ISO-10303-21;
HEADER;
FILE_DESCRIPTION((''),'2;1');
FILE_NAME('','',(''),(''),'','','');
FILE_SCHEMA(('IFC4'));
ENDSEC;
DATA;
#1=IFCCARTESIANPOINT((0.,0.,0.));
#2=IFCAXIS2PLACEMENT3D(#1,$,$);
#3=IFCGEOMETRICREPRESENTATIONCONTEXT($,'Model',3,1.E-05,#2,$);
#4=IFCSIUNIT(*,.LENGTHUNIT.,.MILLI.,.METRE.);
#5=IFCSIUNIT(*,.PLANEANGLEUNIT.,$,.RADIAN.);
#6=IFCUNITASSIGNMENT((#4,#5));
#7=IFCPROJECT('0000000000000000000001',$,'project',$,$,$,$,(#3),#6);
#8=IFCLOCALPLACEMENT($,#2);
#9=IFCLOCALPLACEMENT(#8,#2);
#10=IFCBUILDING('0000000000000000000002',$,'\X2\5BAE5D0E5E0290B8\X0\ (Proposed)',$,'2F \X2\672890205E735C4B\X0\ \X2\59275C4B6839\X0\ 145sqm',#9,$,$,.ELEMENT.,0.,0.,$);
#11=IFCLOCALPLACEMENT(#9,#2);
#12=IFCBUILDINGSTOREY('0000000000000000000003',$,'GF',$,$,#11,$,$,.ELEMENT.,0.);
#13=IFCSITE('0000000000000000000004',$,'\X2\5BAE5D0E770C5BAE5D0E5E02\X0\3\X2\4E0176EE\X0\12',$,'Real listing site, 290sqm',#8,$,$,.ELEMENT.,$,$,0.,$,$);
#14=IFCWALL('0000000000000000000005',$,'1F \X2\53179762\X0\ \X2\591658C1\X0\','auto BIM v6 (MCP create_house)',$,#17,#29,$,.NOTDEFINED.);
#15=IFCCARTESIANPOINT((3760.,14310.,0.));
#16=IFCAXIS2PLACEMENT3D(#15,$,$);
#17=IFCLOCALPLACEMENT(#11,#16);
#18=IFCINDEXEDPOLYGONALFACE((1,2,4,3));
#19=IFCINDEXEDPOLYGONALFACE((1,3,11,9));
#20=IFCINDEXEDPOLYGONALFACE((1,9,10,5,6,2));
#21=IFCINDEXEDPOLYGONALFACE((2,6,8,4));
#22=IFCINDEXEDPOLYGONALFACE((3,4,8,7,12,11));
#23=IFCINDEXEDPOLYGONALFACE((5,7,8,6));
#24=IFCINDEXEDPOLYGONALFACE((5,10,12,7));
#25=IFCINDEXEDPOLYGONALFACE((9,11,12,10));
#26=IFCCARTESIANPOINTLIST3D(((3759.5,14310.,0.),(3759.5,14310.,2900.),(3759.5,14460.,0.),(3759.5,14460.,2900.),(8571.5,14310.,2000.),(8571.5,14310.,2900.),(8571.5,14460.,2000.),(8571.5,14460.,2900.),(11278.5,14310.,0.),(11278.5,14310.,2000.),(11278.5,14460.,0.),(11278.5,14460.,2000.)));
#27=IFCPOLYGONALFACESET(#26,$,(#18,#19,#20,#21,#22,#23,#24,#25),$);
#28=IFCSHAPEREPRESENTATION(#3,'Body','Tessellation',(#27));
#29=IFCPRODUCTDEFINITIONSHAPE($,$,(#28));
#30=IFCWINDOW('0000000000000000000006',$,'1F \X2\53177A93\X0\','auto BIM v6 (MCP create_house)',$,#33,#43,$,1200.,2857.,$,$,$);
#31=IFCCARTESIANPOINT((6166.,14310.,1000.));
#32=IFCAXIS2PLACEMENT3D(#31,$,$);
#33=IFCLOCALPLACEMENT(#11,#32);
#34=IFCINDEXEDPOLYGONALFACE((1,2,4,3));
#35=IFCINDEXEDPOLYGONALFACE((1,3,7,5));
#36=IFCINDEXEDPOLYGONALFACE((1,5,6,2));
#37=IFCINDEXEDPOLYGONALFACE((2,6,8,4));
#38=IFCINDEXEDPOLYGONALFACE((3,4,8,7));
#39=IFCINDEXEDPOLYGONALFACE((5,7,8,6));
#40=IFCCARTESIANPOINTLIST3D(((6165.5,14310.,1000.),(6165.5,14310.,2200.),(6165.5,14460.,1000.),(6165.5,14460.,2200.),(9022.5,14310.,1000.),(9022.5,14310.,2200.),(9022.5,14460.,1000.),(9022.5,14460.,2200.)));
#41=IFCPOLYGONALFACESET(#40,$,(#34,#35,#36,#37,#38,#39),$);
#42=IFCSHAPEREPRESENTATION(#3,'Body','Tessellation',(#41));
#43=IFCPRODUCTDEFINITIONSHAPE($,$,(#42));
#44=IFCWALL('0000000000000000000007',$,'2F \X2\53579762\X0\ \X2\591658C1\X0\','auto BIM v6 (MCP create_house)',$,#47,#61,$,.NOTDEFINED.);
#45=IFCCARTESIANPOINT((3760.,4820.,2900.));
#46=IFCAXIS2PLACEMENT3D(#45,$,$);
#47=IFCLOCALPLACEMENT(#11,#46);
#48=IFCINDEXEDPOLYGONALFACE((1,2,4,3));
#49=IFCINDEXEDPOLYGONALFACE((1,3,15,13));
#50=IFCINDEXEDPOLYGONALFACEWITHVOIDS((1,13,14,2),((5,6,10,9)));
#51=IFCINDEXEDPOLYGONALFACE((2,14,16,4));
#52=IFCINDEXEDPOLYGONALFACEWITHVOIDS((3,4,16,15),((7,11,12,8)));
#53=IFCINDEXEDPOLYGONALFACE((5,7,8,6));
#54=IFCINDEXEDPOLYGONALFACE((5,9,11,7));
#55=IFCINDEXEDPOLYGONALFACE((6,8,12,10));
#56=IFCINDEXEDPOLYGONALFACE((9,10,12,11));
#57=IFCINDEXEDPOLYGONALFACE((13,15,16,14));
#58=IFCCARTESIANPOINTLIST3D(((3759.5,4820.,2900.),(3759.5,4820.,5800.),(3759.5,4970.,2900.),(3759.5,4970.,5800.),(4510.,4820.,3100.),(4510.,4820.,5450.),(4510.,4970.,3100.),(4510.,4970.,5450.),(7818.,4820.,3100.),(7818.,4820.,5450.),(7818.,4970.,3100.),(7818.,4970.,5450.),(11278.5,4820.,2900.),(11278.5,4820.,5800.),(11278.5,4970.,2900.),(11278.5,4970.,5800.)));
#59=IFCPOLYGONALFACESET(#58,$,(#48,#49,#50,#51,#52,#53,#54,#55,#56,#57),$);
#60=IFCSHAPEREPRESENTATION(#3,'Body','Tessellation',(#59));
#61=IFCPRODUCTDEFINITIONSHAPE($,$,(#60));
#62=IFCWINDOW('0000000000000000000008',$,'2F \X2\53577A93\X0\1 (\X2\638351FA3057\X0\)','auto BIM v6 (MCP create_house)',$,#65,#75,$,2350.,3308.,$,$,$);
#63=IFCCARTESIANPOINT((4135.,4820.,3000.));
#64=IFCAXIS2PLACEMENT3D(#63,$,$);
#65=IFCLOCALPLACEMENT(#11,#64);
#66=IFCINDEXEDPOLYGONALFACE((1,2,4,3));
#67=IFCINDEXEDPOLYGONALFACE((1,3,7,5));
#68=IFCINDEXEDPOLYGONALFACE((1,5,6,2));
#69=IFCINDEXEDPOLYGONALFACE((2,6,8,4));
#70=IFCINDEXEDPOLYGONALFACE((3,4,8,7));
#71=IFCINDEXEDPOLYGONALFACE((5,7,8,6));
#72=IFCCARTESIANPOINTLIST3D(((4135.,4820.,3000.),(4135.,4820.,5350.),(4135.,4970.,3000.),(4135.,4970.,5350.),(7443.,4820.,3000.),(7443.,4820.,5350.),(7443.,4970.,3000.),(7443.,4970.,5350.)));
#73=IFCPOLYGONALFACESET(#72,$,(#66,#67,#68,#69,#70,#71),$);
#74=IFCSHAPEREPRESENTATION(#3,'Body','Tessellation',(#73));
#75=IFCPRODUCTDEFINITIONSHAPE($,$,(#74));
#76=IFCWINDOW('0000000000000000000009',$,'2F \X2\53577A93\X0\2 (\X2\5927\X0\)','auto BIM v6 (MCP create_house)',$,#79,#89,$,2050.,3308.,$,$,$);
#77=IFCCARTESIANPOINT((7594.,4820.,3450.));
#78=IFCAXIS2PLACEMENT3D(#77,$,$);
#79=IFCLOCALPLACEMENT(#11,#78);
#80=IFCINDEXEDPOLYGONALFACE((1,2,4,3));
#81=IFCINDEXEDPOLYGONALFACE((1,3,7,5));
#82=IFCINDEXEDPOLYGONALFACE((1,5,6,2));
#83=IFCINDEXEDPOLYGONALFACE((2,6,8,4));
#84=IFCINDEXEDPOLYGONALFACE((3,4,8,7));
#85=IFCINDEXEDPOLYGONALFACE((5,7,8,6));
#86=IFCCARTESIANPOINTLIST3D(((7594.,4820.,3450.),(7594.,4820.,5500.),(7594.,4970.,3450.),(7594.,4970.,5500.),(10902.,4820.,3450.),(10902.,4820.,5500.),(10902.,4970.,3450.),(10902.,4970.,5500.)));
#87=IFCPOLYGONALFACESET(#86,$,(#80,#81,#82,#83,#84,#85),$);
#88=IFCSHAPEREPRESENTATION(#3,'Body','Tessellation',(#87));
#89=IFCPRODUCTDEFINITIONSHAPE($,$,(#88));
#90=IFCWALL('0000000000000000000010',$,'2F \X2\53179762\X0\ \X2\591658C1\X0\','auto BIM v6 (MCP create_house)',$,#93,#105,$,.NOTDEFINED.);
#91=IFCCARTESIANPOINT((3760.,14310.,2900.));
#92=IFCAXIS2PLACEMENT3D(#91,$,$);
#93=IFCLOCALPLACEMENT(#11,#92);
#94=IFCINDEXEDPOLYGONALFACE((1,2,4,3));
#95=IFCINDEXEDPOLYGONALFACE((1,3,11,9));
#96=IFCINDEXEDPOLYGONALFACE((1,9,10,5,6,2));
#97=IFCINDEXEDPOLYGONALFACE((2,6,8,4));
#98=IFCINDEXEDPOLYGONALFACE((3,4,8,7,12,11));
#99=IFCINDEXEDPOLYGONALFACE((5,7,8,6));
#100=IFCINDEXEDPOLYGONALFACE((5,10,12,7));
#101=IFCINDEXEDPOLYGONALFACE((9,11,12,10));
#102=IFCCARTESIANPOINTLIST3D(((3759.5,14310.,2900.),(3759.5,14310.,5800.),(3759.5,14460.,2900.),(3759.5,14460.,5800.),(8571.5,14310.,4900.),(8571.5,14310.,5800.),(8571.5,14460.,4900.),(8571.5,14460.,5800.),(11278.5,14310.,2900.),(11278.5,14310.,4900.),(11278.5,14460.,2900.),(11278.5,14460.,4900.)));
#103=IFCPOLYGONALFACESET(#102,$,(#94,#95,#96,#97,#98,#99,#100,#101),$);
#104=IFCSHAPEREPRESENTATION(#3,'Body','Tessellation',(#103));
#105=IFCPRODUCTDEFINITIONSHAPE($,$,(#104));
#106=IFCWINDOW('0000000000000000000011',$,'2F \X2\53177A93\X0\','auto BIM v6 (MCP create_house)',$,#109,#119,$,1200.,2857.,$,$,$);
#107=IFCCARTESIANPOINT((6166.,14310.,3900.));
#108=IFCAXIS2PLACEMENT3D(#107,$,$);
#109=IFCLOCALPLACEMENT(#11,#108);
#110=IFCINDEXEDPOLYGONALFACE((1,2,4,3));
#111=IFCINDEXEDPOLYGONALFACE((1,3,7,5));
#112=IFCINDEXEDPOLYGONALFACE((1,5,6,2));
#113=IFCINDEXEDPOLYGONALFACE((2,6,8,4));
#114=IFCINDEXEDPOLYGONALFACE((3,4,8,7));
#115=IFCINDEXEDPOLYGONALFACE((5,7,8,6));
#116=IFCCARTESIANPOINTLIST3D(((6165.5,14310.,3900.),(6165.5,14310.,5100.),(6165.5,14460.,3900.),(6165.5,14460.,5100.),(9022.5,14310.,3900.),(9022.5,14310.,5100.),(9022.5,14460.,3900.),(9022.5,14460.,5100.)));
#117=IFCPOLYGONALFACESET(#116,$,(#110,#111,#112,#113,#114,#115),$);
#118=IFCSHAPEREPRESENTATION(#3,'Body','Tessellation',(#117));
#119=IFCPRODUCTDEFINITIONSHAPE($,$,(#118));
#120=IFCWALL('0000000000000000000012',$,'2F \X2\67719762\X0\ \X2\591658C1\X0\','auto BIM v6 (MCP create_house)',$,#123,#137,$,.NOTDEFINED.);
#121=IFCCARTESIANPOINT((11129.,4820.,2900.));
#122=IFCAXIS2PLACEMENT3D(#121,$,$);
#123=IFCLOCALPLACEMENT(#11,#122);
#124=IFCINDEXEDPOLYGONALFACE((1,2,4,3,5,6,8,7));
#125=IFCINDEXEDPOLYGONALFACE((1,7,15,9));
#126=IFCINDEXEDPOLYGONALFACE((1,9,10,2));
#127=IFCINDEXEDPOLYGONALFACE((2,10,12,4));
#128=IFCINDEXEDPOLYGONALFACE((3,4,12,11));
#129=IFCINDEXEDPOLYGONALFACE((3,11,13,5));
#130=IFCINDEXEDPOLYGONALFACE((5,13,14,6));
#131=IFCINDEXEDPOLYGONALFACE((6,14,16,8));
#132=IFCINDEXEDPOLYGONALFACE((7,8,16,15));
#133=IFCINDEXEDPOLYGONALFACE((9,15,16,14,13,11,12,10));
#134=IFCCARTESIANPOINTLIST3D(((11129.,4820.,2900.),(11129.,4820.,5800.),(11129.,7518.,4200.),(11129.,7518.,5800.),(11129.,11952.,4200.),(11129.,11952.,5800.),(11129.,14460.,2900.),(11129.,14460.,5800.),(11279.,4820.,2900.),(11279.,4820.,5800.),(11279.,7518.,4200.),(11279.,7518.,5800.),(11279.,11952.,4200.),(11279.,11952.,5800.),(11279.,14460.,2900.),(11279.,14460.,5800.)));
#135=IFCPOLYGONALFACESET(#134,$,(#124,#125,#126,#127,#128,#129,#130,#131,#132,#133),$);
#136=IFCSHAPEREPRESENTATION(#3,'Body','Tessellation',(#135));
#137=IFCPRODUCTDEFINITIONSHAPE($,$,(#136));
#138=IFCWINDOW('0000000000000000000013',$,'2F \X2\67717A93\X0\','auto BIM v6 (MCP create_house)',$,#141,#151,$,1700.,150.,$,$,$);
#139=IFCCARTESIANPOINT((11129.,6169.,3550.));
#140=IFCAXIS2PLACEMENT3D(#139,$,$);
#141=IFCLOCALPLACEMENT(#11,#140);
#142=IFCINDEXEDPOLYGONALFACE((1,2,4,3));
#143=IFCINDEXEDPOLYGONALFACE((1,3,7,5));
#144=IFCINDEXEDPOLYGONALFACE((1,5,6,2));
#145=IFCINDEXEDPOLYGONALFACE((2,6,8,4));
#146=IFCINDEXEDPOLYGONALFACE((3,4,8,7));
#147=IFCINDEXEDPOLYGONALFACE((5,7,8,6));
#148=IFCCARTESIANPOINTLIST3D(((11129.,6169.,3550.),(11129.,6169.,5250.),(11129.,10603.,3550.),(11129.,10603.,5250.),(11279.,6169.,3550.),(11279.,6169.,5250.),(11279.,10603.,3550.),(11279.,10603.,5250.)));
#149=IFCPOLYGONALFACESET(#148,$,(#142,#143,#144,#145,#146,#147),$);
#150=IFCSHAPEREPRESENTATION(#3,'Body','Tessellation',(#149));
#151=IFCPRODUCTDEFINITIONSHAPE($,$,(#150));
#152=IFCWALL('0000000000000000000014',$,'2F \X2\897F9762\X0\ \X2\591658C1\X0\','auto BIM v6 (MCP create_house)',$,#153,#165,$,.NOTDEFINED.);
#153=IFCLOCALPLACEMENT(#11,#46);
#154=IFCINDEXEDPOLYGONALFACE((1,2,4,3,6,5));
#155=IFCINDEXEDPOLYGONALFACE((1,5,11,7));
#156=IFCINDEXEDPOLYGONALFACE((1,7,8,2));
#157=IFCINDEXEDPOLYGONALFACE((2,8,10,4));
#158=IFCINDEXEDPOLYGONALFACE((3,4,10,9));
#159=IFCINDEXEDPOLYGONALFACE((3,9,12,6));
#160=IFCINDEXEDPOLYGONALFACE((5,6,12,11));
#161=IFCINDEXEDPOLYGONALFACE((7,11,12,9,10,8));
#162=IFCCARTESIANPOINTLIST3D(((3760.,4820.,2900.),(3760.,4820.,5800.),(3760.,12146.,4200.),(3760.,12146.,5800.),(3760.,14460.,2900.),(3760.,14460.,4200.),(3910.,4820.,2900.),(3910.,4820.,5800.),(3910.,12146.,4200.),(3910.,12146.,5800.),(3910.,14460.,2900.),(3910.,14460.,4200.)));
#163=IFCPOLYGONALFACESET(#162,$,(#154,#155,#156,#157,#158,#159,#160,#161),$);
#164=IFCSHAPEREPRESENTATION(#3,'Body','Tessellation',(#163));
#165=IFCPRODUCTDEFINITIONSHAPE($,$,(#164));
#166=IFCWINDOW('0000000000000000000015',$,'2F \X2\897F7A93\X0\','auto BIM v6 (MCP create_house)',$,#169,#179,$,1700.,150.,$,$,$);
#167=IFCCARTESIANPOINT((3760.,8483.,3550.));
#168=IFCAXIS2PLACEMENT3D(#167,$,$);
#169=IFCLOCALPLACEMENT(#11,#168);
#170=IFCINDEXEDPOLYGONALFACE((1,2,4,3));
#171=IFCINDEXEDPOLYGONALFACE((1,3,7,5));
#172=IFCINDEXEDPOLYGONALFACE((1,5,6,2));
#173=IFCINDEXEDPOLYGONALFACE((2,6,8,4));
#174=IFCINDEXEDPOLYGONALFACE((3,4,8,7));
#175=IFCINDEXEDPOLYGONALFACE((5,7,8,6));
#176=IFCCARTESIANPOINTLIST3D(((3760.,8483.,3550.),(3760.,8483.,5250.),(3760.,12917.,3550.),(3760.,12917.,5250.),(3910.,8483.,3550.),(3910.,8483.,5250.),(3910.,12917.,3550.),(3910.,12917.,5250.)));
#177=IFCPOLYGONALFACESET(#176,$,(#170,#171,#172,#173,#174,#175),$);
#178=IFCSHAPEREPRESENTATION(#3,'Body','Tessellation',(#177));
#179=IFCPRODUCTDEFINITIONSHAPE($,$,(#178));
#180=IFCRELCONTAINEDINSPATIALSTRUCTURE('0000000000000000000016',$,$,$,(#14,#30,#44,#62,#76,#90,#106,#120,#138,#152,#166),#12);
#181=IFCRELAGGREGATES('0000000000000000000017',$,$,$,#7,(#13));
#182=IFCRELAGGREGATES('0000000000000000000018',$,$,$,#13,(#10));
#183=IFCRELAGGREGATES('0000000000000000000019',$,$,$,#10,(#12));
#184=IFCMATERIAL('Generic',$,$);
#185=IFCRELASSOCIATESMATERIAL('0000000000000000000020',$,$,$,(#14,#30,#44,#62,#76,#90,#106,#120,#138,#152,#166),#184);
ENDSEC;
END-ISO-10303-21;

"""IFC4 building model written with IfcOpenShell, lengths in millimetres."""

from ifc_helpers import new_model, si_unit, frame, frame_2d, origin, place, context, project, spatial, rectangle, extrude, material, element, fill, save


model = new_model("IFC4")

# Units and contexts
model_context = context("Model", 3, precision=1e-05, world=origin())
ifc_project = project(units=[si_unit("LENGTHUNIT", "METRE", prefix="MILLI"), si_unit("PLANEANGLEUNIT", "RADIAN")], contexts=[model_context])

# Site, building, storey
site_placement = place(None, origin())
site = spatial("IfcSite", under=ifc_project, at=site_placement, Name="宮崎県宮崎市3丁目12", ObjectType="Real listing site, 290sqm", CompositionType="ELEMENT", RefElevation=0.0)
building_placement = place(site_placement, origin())
building = spatial("IfcBuilding", under=site, at=building_placement, Name="宮崎市邸 (Proposed)", ObjectType="2F 木造平屋 大屋根 145sqm", CompositionType="ELEMENT", ElevationOfRefHeight=0.0, ElevationOfTerrain=0.0)
storey_placement = place(building_placement, origin())
storey = spatial("IfcBuildingStorey", under=building, at=storey_placement, Name="GF", CompositionType="ELEMENT", Elevation=0.0)

# Wall, opening, window
ifc_material = material(Name="Generic")
wall_1_placement = place(storey_placement, frame((3760.0, 14310.0, 0.0)))
wall_1 = element("IfcWall", 1, at=wall_1_placement, inside=storey, material=ifc_material, Name="1F 北面 外壁", Description="auto BIM v6 (MCP create_house)", PredefinedType="NOTDEFINED", context=model_context, shape_type="SweptSolid", body=[
    extrude(rectangle(XDim=7519.0, YDim=150.0, at=frame_2d((3759.0, 75.0))), frame((3760.0, 14310.0, 0.0)), (0.0, 0.0, 1.0), 2900.0),
])
opening_1_placement = place(storey_placement, frame((6166.0, 14310.0, 1000.0)))
opening_1 = element("IfcOpeningElement", 2, at=opening_1_placement, cuts=wall_1, PredefinedType="NOTDEFINED", context=model_context, shape_type="SweptSolid", body=[
    extrude(rectangle(XDim=2857.0, YDim=150.0, at=frame_2d((1428.0, 75.0))), frame((6166.0, 14310.0, 1000.0)), (0.0, 0.0, 1.0), 1200.0),
])
window_1_placement = place(storey_placement, frame((6166.0, 14310.0, 1000.0)))
window_1 = element("IfcWindow", 3, at=window_1_placement, inside=storey, material=ifc_material, Name="1F 北窓", Description="auto BIM v6 (MCP create_house)", OverallHeight=1200.0, OverallWidth=2857.0, context=model_context, shape_type="SweptSolid", body=[
    extrude(rectangle(XDim=2857.0, YDim=150.0, at=frame_2d((1428.0, 75.0))), frame((6166.0, 14310.0, 1000.0)), (0.0, 0.0, 1.0), 1200.0),
])
fill(opening_1, window_1)

# Wall, openings, windows
wall_2_placement = place(storey_placement, frame((3760.0, 4820.0, 2900.0)))
wall_2 = element("IfcWall", 4, at=wall_2_placement, inside=storey, material=ifc_material, Name="2F 南面 外壁", Description="auto BIM v6 (MCP create_house)", PredefinedType="NOTDEFINED", context=model_context, shape_type="SweptSolid", body=[
    extrude(rectangle(XDim=7519.0, YDim=150.0, at=frame_2d((3759.0, 75.0))), frame((3760.0, 4820.0, 2900.0)), (0.0, 0.0, 1.0), 2900.0),
])
opening_2_placement = place(storey_placement, frame((4135.0, 4820.0, 3000.0)))
opening_2 = element("IfcOpeningElement", 5, at=opening_2_placement, cuts=wall_2, PredefinedType="NOTDEFINED", context=model_context, shape_type="SweptSolid", body=[
    extrude(rectangle(XDim=3308.0, YDim=150.0, at=frame_2d((1654.0, 75.0))), frame((4135.0, 4820.0, 3000.0)), (0.0, 0.0, 1.0), 2350.0),
])
opening_3_placement = place(storey_placement, frame((7594.0, 4820.0, 3450.0)))
opening_3 = element("IfcOpeningElement", 6, at=opening_3_placement, cuts=wall_2, PredefinedType="NOTDEFINED", context=model_context, shape_type="SweptSolid", body=[
    extrude(rectangle(XDim=3308.0, YDim=150.0, at=frame_2d((1654.0, 75.0))), frame((7594.0, 4820.0, 3450.0)), (0.0, 0.0, 1.0), 2050.0),
])
window_2_placement = place(storey_placement, frame((4135.0, 4820.0, 3000.0)))
window_2 = element("IfcWindow", 7, at=window_2_placement, inside=storey, material=ifc_material, Name="2F 南窓1 (掃出し)", Description="auto BIM v6 (MCP create_house)", OverallHeight=2350.0, OverallWidth=3308.0, context=model_context, shape_type="SweptSolid", body=[
    extrude(rectangle(XDim=3308.0, YDim=150.0, at=frame_2d((1654.0, 75.0))), frame((4135.0, 4820.0, 3000.0)), (0.0, 0.0, 1.0), 2350.0),
])
fill(opening_2, window_2)
window_3_placement = place(storey_placement, frame((7594.0, 4820.0, 3450.0)))
window_3 = element("IfcWindow", 8, at=window_3_placement, inside=storey, material=ifc_material, Name="2F 南窓2 (大)", Description="auto BIM v6 (MCP create_house)", OverallHeight=2050.0, OverallWidth=3308.0, context=model_context, shape_type="SweptSolid", body=[
    extrude(rectangle(XDim=3308.0, YDim=150.0, at=frame_2d((1654.0, 75.0))), frame((7594.0, 4820.0, 3450.0)), (0.0, 0.0, 1.0), 2050.0),
])
fill(opening_3, window_3)

# Walls, openings, windows
wall_3_placement = place(storey_placement, frame((3760.0, 14310.0, 2900.0)))
wall_3 = element("IfcWall", 9, at=wall_3_placement, inside=storey, material=ifc_material, Name="2F 北面 外壁", Description="auto BIM v6 (MCP create_house)", PredefinedType="NOTDEFINED", context=model_context, shape_type="SweptSolid", body=[
    extrude(rectangle(XDim=7519.0, YDim=150.0, at=frame_2d((3759.0, 75.0))), frame((3760.0, 14310.0, 2900.0)), (0.0, 0.0, 1.0), 2900.0),
])
opening_4_placement = place(storey_placement, frame((6166.0, 14310.0, 3900.0)))
opening_4 = element("IfcOpeningElement", 10, at=opening_4_placement, cuts=wall_3, PredefinedType="NOTDEFINED", context=model_context, shape_type="SweptSolid", body=[
    extrude(rectangle(XDim=2857.0, YDim=150.0, at=frame_2d((1428.0, 75.0))), frame((6166.0, 14310.0, 3900.0)), (0.0, 0.0, 1.0), 1200.0),
])
window_4_placement = place(storey_placement, frame((6166.0, 14310.0, 3900.0)))
window_4 = element("IfcWindow", 11, at=window_4_placement, inside=storey, material=ifc_material, Name="2F 北窓", Description="auto BIM v6 (MCP create_house)", OverallHeight=1200.0, OverallWidth=2857.0, context=model_context, shape_type="SweptSolid", body=[
    extrude(rectangle(XDim=2857.0, YDim=150.0, at=frame_2d((1428.0, 75.0))), frame((6166.0, 14310.0, 3900.0)), (0.0, 0.0, 1.0), 1200.0),
])
fill(opening_4, window_4)
wall_4_placement = place(storey_placement, frame((11129.0, 4820.0, 2900.0)))
wall_4 = element("IfcWall", 12, at=wall_4_placement, inside=storey, material=ifc_material, Name="2F 東面 外壁", Description="auto BIM v6 (MCP create_house)", PredefinedType="NOTDEFINED", context=model_context, shape_type="SweptSolid", body=[
    extrude(rectangle(XDim=150.0, YDim=9640.0, at=frame_2d((75.0, 4820.0))), frame((11129.0, 4820.0, 2900.0)), (0.0, 0.0, 1.0), 2900.0),
])
opening_5_placement = place(storey_placement, frame((11129.0, 6169.0, 3550.0)))
opening_5 = element("IfcOpeningElement", 13, at=opening_5_placement, cuts=wall_4, PredefinedType="NOTDEFINED", context=model_context, shape_type="SweptSolid", body=[
    extrude(rectangle(XDim=150.0, YDim=4434.0, at=frame_2d((75.0, 2217.0))), frame((11129.0, 6169.0, 3550.0)), (0.0, 0.0, 1.0), 1700.0),
])
window_5_placement = place(storey_placement, frame((11129.0, 6169.0, 3550.0)))
window_5 = element("IfcWindow", 14, at=window_5_placement, inside=storey, material=ifc_material, Name="2F 東窓", Description="auto BIM v6 (MCP create_house)", OverallHeight=1700.0, OverallWidth=150.0, context=model_context, shape_type="SweptSolid", body=[
    extrude(rectangle(XDim=150.0, YDim=4434.0, at=frame_2d((75.0, 2217.0))), frame((11129.0, 6169.0, 3550.0)), (0.0, 0.0, 1.0), 1700.0),
])
fill(opening_5, window_5)
wall_5_placement = place(storey_placement, frame((3760.0, 4820.0, 2900.0)))
wall_5 = element("IfcWall", 15, at=wall_5_placement, inside=storey, material=ifc_material, Name="2F 西面 外壁", Description="auto BIM v6 (MCP create_house)", PredefinedType="NOTDEFINED", context=model_context, shape_type="SweptSolid", body=[
    extrude(rectangle(XDim=150.0, YDim=9640.0, at=frame_2d((75.0, 4820.0))), frame((3760.0, 4820.0, 2900.0)), (0.0, 0.0, 1.0), 2900.0),
])
opening_6_placement = place(storey_placement, frame((3760.0, 8483.0, 3550.0)))
opening_6 = element("IfcOpeningElement", 16, at=opening_6_placement, cuts=wall_5, PredefinedType="NOTDEFINED", context=model_context, shape_type="SweptSolid", body=[
    extrude(rectangle(XDim=150.0, YDim=4434.0, at=frame_2d((75.0, 2217.0))), frame((3760.0, 8483.0, 3550.0)), (0.0, 0.0, 1.0), 1700.0),
])
window_6_placement = place(storey_placement, frame((3760.0, 8483.0, 3550.0)))
window_6 = element("IfcWindow", 17, at=window_6_placement, inside=storey, material=ifc_material, Name="2F 西窓", Description="auto BIM v6 (MCP create_house)", OverallHeight=1700.0, OverallWidth=150.0, context=model_context, shape_type="SweptSolid", body=[
    extrude(rectangle(XDim=150.0, YDim=4434.0, at=frame_2d((75.0, 2217.0))), frame((3760.0, 8483.0, 3550.0)), (0.0, 0.0, 1.0), 1700.0),
])
fill(opening_6, window_6)

save(model, "model.ifc")
